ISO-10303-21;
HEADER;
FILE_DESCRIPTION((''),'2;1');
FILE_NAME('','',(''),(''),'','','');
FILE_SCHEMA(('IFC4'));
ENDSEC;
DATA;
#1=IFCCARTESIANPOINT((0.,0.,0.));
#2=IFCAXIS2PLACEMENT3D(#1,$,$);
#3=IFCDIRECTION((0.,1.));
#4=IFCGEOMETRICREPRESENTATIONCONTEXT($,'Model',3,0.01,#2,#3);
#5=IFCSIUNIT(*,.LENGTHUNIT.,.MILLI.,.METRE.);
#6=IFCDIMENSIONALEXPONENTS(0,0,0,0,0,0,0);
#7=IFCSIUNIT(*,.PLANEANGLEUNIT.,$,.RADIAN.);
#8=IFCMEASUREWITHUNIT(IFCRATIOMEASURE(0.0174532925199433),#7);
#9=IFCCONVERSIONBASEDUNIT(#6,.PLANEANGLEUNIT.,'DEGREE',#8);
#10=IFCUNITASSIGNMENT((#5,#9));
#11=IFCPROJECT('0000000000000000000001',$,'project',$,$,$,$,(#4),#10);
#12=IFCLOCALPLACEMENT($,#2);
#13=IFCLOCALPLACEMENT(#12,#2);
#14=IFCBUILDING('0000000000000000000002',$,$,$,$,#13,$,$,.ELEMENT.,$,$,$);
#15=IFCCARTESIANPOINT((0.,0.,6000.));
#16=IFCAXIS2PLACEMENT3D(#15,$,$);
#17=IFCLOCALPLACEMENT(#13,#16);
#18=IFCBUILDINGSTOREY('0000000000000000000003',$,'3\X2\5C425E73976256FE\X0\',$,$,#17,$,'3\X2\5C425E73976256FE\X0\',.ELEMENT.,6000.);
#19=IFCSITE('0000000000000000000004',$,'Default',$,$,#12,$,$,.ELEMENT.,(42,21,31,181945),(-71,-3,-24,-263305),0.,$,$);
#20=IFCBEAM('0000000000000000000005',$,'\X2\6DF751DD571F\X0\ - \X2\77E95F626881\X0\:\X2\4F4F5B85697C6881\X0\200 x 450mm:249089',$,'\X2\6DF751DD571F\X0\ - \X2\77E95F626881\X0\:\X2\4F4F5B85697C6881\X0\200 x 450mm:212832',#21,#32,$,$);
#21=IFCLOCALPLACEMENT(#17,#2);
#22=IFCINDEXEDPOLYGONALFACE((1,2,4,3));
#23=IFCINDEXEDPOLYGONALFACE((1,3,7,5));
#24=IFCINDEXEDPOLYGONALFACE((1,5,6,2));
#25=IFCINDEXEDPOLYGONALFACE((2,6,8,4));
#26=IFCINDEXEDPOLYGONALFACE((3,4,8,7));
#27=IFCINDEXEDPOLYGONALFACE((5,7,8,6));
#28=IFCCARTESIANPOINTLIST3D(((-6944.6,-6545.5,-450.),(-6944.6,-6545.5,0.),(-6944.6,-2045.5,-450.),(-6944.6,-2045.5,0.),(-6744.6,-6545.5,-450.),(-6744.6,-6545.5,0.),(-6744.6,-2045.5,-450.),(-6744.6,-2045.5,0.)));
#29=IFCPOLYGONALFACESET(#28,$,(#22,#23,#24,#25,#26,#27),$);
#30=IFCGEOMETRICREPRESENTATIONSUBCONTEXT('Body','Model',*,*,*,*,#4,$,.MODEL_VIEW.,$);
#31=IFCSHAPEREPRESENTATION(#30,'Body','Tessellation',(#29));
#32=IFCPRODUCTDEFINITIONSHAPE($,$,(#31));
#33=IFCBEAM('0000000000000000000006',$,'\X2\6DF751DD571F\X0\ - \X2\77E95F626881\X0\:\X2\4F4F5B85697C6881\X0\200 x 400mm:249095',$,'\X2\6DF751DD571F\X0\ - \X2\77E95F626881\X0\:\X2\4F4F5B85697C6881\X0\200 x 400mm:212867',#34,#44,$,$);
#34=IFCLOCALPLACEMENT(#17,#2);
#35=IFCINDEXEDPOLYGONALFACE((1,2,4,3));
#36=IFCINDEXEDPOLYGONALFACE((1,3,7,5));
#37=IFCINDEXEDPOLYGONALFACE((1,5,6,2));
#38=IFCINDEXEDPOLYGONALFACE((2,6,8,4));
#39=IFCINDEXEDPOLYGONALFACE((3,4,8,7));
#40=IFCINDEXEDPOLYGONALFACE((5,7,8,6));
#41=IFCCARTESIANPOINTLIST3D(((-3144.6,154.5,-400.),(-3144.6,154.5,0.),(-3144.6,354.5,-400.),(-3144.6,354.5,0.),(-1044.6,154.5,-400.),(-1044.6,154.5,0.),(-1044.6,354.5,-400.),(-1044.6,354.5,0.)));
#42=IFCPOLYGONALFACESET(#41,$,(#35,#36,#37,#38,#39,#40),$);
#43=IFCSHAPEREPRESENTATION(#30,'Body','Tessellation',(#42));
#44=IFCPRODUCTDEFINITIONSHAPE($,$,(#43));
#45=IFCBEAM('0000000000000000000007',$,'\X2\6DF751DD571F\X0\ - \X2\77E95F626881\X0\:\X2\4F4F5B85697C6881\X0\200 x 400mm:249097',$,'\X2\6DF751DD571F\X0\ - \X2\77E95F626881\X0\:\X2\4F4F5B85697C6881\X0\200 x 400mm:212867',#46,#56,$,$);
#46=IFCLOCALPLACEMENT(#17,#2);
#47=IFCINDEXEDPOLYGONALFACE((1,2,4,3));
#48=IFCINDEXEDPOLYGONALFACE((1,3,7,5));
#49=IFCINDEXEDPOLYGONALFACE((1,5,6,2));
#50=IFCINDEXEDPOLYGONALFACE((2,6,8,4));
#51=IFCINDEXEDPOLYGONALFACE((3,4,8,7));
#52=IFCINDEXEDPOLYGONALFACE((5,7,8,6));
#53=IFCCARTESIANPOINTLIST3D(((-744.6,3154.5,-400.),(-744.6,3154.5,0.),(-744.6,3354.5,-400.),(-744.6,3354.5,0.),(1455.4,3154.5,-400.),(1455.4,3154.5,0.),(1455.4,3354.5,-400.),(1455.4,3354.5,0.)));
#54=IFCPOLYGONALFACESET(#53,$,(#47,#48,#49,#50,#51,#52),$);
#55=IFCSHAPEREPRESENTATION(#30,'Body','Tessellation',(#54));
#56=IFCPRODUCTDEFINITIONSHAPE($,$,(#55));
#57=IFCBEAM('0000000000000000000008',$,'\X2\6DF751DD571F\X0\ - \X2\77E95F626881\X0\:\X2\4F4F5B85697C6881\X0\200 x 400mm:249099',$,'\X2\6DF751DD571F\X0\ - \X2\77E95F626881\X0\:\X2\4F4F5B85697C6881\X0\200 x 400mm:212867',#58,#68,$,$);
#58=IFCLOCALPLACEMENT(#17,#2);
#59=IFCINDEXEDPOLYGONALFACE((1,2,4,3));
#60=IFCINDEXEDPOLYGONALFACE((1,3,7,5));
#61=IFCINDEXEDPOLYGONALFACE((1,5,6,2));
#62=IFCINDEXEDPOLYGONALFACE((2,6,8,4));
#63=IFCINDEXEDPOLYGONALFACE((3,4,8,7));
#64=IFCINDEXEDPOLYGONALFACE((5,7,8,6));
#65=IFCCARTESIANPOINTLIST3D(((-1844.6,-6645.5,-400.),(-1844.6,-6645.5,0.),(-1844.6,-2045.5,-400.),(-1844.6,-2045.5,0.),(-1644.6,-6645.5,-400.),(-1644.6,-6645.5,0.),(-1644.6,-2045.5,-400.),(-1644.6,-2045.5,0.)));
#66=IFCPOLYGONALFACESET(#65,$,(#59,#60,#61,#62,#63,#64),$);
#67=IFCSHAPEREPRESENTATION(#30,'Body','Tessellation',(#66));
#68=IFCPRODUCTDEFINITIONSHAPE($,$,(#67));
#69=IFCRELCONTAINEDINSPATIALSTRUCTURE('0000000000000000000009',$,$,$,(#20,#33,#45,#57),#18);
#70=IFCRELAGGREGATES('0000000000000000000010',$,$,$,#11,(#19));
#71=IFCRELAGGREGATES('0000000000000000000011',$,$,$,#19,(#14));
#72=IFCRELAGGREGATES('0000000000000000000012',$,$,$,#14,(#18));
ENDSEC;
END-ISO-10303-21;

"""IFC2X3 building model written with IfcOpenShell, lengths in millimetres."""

from ifc_helpers import new_model, entity, si_unit, converted_unit, direction, frame, frame_2d, origin, origin_2d_with_axis, place, context, subcontext, project, spatial, rectangle, extrude, element, save


model = new_model("IFC2X3")

# Units and contexts
model_context = context("Model", 3, precision=0.01, world=origin(), true_north=direction((0.0, 1.0)))
body_context = subcontext(model_context, "Body", "Model", "MODEL_VIEW")
ifc_project = project(units=[si_unit("LENGTHUNIT", "METRE", prefix="MILLI"), converted_unit("PLANEANGLEUNIT", "DEGREE", entity("IfcRatioMeasure", 0.0174532925199433), si_unit("PLANEANGLEUNIT", "RADIAN"), dimensions=[0, 0, 0, 0, 0, 0, 0])], contexts=[model_context])

# Site, building, storey
site_placement = place(None, origin())
site = spatial("IfcSite", under=ifc_project, at=site_placement, Name="Default", CompositionType="ELEMENT", RefLatitude=(42, 21, 31, 181945), RefLongitude=(-71, -3, -24, -263305), RefElevation=0.0)
building_placement = place(site_placement, origin())
building = spatial("IfcBuilding", under=site, at=building_placement, CompositionType="ELEMENT")
storey_placement = place(building_placement, frame((0.0, 0.0, 6000.0)))
storey = spatial("IfcBuildingStorey", under=building, at=storey_placement, Name="3层平面图", LongName="3层平面图", CompositionType="ELEMENT", Elevation=6000.0)

# Beams
beam_1_placement = place(storey_placement, frame((-6844.6, -1945.5, 0.0), z_axis=(0.0, 0.0, 1.0), x_axis=(0.0, -1.0, 0.0)))
element("IfcBeam", 1, at=beam_1_placement, inside=storey, Name="混凝土 - 矩形梁:住宅楼梁200 x 450mm:249089", ObjectType="混凝土 - 矩形梁:住宅楼梁200 x 450mm:212832", context=body_context, shape_type="SweptSolid", body=[
    extrude(rectangle(XDim=450.0, YDim=200.0, at=frame_2d((0.0, 0.0), x_axis=(1.0, 0.0))), frame((100.0, 0.0, -225.0), z_axis=(1.0, 0.0, 0.0), x_axis=(0.0, 0.0, -1.0)), (0.0, 0.0, 1.0), 4500.0),
])
beam_2_placement = place(storey_placement, frame((-3244.6, 254.5, 0.0)))
element("IfcBeam", 2, at=beam_2_placement, inside=storey, Name="混凝土 - 矩形梁:住宅楼梁200 x 400mm:249095", ObjectType="混凝土 - 矩形梁:住宅楼梁200 x 400mm:212867", context=body_context, shape_type="SweptSolid", body=[
    extrude(rectangle(XDim=400.0, YDim=200.0, at=frame_2d((0.0, 0.0), x_axis=(1.0, 0.0))), frame((100.0, 0.0, -200.0), z_axis=(1.0, 0.0, 0.0), x_axis=(0.0, 0.0, -1.0)), (0.0, 0.0, 1.0), 2100.0),
])
beam_3_placement = place(storey_placement, frame((-944.6, 3254.5, 0.0)))
element("IfcBeam", 3, at=beam_3_placement, inside=storey, Name="混凝土 - 矩形梁:住宅楼梁200 x 400mm:249097", ObjectType="混凝土 - 矩形梁:住宅楼梁200 x 400mm:212867", context=body_context, shape_type="SweptSolid", body=[
    extrude(rectangle(XDim=400.0, YDim=200.0, at=frame_2d((0.0, 0.0), x_axis=(1.0, 0.0))), frame((200.0, 0.0, -200.0), z_axis=(1.0, 0.0, 0.0), x_axis=(0.0, 0.0, -1.0)), (0.0, 0.0, 1.0), 2200.0),
])
beam_4_placement = place(storey_placement, frame((-1744.6, -1945.5, 0.0), z_axis=(0.0, 0.0, 1.0), x_axis=(0.0, -1.0, 0.0)))
element("IfcBeam", 4, at=beam_4_placement, inside=storey, Name="混凝土 - 矩形梁:住宅楼梁200 x 400mm:249099", ObjectType="混凝土 - 矩形梁:住宅楼梁200 x 400mm:212867", context=body_context, shape_type="SweptSolid", body=[
    extrude(rectangle(XDim=400.0, YDim=200.0, at=origin_2d_with_axis()), frame((100.0, 0.0, -200.0), z_axis=(1.0, 0.0, 0.0), x_axis=(0.0, 0.0, -1.0)), (0.0, 0.0, 1.0), 4600.0),
])

save(model, "model.ifc")
